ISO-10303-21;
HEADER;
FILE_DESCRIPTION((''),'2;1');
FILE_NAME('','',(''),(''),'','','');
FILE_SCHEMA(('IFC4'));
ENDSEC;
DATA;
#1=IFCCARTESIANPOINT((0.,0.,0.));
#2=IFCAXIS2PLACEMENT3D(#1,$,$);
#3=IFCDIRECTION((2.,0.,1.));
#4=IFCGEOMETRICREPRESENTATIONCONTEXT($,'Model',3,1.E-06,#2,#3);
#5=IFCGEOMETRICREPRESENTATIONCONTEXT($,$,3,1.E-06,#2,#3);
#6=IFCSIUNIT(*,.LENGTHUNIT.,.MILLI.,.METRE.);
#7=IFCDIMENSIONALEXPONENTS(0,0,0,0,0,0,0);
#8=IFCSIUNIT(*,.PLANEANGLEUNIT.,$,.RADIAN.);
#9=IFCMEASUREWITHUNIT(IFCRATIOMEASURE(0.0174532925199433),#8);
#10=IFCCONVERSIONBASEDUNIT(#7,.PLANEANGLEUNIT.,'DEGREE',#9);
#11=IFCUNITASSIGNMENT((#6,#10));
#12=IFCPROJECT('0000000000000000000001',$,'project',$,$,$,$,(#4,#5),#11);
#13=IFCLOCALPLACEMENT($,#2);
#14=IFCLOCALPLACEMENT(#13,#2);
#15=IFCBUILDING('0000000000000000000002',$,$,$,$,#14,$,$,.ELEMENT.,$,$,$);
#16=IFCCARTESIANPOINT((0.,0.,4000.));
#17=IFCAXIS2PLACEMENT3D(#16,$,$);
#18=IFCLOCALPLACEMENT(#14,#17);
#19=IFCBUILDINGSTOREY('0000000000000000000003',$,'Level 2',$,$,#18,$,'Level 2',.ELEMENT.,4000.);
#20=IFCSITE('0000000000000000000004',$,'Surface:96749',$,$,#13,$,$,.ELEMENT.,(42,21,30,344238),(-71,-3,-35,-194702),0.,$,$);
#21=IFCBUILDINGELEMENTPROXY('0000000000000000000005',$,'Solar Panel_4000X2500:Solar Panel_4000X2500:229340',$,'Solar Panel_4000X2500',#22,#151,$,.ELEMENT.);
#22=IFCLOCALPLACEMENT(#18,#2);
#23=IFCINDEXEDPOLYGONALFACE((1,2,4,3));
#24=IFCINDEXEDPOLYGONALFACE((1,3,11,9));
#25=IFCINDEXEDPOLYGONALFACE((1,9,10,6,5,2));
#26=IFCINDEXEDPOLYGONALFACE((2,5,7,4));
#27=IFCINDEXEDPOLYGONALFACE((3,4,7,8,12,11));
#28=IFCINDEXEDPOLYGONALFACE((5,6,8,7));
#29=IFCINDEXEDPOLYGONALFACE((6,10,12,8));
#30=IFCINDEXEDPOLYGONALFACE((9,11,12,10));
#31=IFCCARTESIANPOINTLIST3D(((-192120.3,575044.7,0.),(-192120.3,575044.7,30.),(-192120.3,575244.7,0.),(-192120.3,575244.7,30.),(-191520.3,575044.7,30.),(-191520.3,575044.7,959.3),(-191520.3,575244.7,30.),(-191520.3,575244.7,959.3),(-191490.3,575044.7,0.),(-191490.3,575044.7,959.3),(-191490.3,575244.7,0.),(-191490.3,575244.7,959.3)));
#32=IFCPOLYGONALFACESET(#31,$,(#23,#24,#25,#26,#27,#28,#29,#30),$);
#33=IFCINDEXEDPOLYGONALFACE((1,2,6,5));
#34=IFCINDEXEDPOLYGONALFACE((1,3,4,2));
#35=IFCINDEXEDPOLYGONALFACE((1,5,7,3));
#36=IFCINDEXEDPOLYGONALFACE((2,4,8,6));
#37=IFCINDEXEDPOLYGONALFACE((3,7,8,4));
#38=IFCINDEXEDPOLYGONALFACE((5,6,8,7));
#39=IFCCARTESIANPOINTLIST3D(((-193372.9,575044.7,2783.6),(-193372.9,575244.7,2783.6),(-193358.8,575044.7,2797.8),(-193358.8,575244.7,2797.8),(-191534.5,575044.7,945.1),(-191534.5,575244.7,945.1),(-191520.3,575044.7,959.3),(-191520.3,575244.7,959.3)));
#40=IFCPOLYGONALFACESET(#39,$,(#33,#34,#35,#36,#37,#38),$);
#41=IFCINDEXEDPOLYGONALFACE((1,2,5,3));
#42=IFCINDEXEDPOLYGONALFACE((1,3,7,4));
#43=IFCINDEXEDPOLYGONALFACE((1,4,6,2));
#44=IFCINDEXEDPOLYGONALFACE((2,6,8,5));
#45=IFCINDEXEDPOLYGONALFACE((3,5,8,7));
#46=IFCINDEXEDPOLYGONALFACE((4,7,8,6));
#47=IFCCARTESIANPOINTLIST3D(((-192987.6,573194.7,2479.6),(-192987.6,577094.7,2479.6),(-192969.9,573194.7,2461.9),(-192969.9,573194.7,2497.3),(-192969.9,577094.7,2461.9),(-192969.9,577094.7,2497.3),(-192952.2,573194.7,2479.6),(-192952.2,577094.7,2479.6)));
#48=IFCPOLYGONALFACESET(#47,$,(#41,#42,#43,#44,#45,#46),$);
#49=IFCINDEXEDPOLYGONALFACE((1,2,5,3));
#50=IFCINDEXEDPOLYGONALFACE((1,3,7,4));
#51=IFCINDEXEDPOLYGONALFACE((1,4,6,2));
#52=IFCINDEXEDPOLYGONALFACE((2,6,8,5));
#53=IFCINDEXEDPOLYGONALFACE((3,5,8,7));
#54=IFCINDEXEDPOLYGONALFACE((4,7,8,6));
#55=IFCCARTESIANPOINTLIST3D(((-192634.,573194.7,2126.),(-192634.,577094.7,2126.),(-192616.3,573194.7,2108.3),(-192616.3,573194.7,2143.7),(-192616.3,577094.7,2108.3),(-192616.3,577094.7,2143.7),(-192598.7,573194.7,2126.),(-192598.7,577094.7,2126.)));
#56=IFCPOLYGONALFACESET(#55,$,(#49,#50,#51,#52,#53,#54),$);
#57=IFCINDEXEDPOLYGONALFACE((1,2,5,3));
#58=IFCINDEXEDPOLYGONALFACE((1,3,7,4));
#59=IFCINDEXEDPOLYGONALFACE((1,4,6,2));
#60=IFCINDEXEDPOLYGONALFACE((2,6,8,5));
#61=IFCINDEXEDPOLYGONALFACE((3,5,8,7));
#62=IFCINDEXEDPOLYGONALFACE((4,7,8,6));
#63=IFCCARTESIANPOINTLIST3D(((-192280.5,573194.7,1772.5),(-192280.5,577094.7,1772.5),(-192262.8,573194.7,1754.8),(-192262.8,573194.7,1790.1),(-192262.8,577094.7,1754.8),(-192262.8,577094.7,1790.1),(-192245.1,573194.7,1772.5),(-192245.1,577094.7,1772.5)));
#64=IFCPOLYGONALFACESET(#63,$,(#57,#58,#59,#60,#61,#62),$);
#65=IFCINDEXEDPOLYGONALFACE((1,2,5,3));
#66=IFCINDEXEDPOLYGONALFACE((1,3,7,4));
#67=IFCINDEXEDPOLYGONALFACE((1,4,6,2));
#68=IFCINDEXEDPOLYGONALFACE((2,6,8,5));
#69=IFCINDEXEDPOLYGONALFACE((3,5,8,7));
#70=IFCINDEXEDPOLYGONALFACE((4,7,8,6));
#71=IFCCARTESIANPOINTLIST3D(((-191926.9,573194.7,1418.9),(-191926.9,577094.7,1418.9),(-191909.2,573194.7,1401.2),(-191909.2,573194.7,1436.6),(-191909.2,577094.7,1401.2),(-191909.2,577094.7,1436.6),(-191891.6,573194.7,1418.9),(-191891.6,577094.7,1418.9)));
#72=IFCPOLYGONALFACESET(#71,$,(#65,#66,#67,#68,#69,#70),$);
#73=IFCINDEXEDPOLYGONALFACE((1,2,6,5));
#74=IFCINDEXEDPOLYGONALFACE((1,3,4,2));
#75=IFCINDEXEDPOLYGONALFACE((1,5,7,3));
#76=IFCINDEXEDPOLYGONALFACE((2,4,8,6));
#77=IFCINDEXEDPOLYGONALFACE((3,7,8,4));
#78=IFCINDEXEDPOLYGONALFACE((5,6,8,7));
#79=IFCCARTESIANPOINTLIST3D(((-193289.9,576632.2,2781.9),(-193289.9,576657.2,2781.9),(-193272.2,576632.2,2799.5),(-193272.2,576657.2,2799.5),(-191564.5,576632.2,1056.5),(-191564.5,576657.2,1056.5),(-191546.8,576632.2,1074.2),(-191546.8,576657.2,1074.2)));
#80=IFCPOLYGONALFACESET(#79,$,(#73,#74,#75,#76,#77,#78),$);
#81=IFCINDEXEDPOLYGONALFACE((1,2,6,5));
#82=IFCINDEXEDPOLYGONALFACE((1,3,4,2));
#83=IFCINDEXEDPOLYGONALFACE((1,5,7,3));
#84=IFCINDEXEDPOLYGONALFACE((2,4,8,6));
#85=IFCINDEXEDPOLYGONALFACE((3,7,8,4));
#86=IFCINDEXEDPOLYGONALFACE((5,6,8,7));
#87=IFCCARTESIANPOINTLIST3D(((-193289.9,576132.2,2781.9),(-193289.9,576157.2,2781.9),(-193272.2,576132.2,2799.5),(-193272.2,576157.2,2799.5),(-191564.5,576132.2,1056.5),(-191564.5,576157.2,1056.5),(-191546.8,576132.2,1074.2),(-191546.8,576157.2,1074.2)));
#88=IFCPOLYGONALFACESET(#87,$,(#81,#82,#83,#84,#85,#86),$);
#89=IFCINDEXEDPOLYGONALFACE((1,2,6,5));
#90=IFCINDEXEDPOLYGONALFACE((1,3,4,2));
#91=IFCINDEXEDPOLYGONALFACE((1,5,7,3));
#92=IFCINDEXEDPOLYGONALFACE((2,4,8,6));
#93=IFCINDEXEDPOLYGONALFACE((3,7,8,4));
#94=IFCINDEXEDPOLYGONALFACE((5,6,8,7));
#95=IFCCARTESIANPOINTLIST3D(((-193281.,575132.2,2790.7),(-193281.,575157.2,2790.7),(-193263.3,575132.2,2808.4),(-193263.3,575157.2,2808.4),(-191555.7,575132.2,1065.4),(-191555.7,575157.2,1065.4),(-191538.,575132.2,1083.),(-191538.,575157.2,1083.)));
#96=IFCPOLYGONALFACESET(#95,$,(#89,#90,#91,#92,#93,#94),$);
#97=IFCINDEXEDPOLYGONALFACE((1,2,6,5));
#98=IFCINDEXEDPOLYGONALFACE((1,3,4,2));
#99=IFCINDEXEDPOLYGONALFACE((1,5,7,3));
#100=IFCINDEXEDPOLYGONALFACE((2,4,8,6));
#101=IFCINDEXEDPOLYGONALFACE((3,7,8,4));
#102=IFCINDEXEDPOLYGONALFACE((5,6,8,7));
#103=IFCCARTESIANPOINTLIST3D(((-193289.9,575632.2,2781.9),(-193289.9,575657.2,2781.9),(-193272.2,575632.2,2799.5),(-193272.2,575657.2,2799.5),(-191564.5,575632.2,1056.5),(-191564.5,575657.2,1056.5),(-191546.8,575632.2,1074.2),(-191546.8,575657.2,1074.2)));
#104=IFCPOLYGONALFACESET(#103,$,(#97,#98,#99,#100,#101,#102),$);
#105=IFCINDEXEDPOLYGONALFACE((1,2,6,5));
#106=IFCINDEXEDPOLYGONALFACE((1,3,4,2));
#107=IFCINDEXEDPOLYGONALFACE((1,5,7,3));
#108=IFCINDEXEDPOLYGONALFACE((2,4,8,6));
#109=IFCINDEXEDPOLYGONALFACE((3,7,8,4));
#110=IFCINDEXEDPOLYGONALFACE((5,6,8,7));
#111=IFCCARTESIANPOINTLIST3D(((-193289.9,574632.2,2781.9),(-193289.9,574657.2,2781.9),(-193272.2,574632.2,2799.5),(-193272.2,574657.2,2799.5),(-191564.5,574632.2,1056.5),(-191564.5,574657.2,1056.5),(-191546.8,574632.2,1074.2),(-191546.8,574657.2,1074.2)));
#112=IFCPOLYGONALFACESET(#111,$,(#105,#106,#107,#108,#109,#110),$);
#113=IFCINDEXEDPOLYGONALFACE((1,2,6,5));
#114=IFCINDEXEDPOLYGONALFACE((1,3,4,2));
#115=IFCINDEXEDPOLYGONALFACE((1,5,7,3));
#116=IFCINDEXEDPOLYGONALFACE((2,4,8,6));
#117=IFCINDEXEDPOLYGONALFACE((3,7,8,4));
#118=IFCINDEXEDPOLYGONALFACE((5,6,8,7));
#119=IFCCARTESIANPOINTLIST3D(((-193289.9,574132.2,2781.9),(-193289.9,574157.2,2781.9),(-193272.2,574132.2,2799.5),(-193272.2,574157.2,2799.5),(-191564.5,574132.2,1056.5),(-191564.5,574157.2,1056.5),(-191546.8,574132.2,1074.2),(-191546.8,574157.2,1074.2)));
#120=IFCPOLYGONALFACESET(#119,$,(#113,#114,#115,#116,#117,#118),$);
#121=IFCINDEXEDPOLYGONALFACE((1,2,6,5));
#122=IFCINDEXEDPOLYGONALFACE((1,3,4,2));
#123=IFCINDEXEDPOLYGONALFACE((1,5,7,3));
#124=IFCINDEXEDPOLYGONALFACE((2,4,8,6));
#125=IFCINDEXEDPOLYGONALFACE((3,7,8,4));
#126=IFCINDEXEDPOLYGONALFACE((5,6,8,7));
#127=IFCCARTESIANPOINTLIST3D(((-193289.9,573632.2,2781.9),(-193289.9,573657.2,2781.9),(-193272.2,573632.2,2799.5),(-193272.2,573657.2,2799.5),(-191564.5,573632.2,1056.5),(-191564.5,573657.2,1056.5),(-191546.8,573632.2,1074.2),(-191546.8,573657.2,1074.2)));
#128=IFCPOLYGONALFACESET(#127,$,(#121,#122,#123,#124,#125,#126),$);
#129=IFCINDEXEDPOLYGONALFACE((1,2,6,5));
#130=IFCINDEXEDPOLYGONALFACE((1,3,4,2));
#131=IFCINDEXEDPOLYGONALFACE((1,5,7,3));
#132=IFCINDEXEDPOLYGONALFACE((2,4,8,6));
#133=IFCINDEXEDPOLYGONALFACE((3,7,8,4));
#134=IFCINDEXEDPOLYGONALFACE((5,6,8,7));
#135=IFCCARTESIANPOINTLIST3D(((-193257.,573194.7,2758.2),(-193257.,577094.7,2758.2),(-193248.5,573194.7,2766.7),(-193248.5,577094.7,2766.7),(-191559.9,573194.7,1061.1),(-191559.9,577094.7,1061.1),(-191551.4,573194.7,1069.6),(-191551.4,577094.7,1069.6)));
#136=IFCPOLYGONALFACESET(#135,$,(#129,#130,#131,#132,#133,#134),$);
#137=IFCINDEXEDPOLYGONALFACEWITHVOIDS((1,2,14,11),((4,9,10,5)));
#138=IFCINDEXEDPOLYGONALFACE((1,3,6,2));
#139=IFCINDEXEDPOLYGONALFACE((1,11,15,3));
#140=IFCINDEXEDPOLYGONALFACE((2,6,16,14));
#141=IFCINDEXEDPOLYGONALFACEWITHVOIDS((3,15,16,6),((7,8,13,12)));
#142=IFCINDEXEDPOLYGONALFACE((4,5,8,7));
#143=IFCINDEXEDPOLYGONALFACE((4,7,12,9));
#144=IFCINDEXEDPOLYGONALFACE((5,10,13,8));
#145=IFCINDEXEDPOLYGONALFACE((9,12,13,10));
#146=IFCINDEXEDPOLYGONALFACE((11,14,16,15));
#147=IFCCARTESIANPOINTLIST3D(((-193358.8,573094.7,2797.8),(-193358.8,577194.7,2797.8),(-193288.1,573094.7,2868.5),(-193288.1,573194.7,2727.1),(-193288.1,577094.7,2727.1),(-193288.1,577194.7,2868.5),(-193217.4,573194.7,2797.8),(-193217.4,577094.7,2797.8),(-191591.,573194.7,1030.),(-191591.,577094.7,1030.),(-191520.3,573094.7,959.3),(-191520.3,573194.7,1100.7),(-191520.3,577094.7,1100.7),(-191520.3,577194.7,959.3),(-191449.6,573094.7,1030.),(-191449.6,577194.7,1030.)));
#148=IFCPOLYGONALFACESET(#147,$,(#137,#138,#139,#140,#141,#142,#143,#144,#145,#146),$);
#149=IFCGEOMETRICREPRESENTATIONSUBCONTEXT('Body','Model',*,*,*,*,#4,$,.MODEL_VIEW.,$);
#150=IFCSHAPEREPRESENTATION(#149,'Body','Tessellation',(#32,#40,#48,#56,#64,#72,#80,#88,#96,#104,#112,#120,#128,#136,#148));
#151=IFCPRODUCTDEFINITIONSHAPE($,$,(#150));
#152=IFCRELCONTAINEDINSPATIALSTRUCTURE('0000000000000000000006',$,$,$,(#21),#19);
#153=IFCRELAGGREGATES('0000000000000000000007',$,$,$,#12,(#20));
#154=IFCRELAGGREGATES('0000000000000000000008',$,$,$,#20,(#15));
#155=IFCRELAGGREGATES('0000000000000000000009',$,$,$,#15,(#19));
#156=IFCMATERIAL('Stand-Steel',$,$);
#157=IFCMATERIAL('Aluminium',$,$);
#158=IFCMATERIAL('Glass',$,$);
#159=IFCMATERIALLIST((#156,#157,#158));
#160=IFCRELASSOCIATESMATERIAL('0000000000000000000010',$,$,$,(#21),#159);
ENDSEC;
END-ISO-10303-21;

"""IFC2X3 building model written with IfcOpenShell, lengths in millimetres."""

from ifc_helpers import new_model, entity, si_unit, converted_unit, direction, frame, frame_2d, origin, origin_2d_with_axis, place, context, subcontext, project, spatial, polyline, rectangle, outline, extrude, source, transform, mapped, material, material_list, element, save


model = new_model("IFC2X3")

# Units and contexts
model_context = context("Model", 3, precision=1e-06, world=origin(), true_north=direction((2.0, 0.0, 1.0)))
context_of_model = context(None, 3, precision=1e-06, world=origin(), true_north=direction((2.0, 0.0, 1.0)))
body_context = subcontext(model_context, "Body", "Model", "MODEL_VIEW")
ifc_project = project(units=[si_unit("LENGTHUNIT", "METRE", prefix="MILLI"), converted_unit("PLANEANGLEUNIT", "DEGREE", entity("IfcRatioMeasure", 0.0174532925199433), si_unit("PLANEANGLEUNIT", "RADIAN"), dimensions=[0, 0, 0, 0, 0, 0, 0])], contexts=[model_context, context_of_model])

# Site, building, storey
site_placement = place(None, origin())
site = spatial("IfcSite", under=ifc_project, at=site_placement, Name="Surface:96749", CompositionType="ELEMENT", RefLatitude=(42, 21, 30, 344238), RefLongitude=(-71, -3, -35, -194702), RefElevation=0.0)
building_placement = place(site_placement, origin())
building = spatial("IfcBuilding", under=site, at=building_placement, CompositionType="ELEMENT")
storey_placement = place(building_placement, frame((0.0, 0.0, 4000.0)))
storey = spatial("IfcBuildingStorey", under=building, at=storey_placement, Name="Level 2", LongName="Level 2", CompositionType="ELEMENT", Elevation=4000.0)

# Building element proxy
ifc_material_1 = material(Name="Stand-Steel")
ifc_material_2 = material(Name="Aluminium")
ifc_material_3 = material(Name="Glass")
shared_shape = source(origin(), body_context, "Body", "SweptSolid", [
    extrude(outline(polyline([(-629.5, -220.0), (329.8, -220.0), (329.8, 410.0), (299.8, 410.0), (299.8, -190.0), (-629.5, -190.0), (-629.5, -220.0)])), frame((-190.0, -100.0, 299.8), z_axis=(0.0, 1.0, 0.0), x_axis=(0.0, 0.0, -1.0)), (0.0, 0.0, 1.0), 200.0),
    extrude(rectangle(XDim=20.0, YDim=200.0, at=frame_2d((0.0, 0.0), x_axis=(0.0, 1.0))), frame((-7.1, 0.0, 922.2), z_axis=(-0.707107, 0.0, 0.707107), x_axis=(0.0, 1.0, 0.0)), (0.0, 0.0, 1.0), 2600.0),
    extrude(rectangle(XDim=25.0, YDim=25.0, at=frame_2d((0.0, 0.0), x_axis=(1.0, 0.0))), frame((-1449.6, -1950.0, 2449.6), z_axis=(0.0, 1.0, 0.0), x_axis=(-0.707107, 0.0, -0.707107)), (0.0, 0.0, 1.0), 3900.0),
    extrude(rectangle(XDim=25.0, YDim=25.0, at=origin_2d_with_axis()), frame((-1096.0, -1950.0, 2096.0), z_axis=(0.0, 1.0, 0.0), x_axis=(-0.707107, 0.0, -0.707107)), (0.0, 0.0, 1.0), 3900.0),
    extrude(rectangle(XDim=25.0, YDim=25.0, at=origin_2d_with_axis()), frame((-742.5, -1950.0, 1742.5), z_axis=(0.0, 1.0, 0.0), x_axis=(-0.707107, 0.0, -0.707107)), (0.0, 0.0, 1.0), 3900.0),
    extrude(rectangle(XDim=25.0, YDim=25.0, at=frame_2d((0.0, 0.0), x_axis=(1.0, 0.0))), frame((-388.9, -1950.0, 1388.9), z_axis=(0.0, 1.0, 0.0), x_axis=(-0.707107, 0.0, -0.707107)), (0.0, 0.0, 1.0), 3900.0),
    extrude(rectangle(XDim=25.0, YDim=25.0, at=frame_2d((0.0, 0.0), x_axis=(0.0, 1.0))), frame((-35.4, 1500.0, 1035.4), z_axis=(-0.707107, 0.0, 0.707107), x_axis=(0.0, 1.0, 0.0)), (0.0, 0.0, 1.0), 2440.0),
    extrude(rectangle(XDim=25.0, YDim=25.0, at=frame_2d((0.0, 0.0), x_axis=(0.0, 1.0))), frame((-35.4, 1000.0, 1035.4), z_axis=(-0.707107, 0.0, 0.707107), x_axis=(0.0, 1.0, 0.0)), (0.0, 0.0, 1.0), 2440.0),
    extrude(rectangle(XDim=25.0, YDim=25.0, at=frame_2d((0.0, 0.0), x_axis=(0.0, 1.0))), frame((-26.5, 0.0, 1044.2), z_axis=(-0.707107, 0.0, 0.707107), x_axis=(0.0, -1.0, 0.0)), (0.0, 0.0, 1.0), 2440.0),
    extrude(rectangle(XDim=25.0, YDim=25.0, at=frame_2d((0.0, 0.0), x_axis=(0.0, 1.0))), frame((-35.4, 500.0, 1035.4), z_axis=(-0.707107, 0.0, 0.707107), x_axis=(0.0, 1.0, 0.0)), (0.0, 0.0, 1.0), 2440.0),
    extrude(rectangle(XDim=25.0, YDim=25.0, at=frame_2d((0.0, 0.0), x_axis=(0.0, 1.0))), frame((-35.4, -500.0, 1035.4), z_axis=(-0.707107, 0.0, 0.707107), x_axis=(0.0, 1.0, 0.0)), (0.0, 0.0, 1.0), 2440.0),
    extrude(rectangle(XDim=25.0, YDim=25.0, at=frame_2d((0.0, 0.0), x_axis=(0.0, 1.0))), frame((-35.4, -1000.0, 1035.4), z_axis=(-0.707107, 0.0, 0.707107), x_axis=(0.0, 1.0, 0.0)), (0.0, 0.0, 1.0), 2440.0),
    extrude(rectangle(XDim=25.0, YDim=25.0, at=frame_2d((0.0, 0.0), x_axis=(0.0, 1.0))), frame((-35.4, -1500.0, 1035.4), z_axis=(-0.707107, 0.0, 0.707107), x_axis=(0.0, 1.0, 0.0)), (0.0, 0.0, 1.0), 2440.0),
    extrude(rectangle(XDim=2400.0, YDim=12.0, at=frame_2d((0.0, 0.0), x_axis=(1.0, 0.0))), frame((-883.9, -1950.0, 1883.9), z_axis=(0.0, 1.0, 0.0), x_axis=(0.707107, 0.0, -0.707107)), (0.0, 0.0, 1.0), 3900.0),
    extrude(outline(polyline([(-2050.0, -1300.0), (2050.0, -1300.0), (2050.0, 1300.0), (-2050.0, 1300.0), (-2050.0, -1300.0)]), holes=[polyline([(1950.0, -1200.0), (-1950.0, -1200.0), (-1950.0, 1200.0), (1950.0, 1200.0), (1950.0, -1200.0)])]), frame((-919.2, 0.0, 1848.5), z_axis=(0.707107, 0.0, 0.707107), x_axis=(0.0, 1.0, 0.0)), (0.0, 0.0, 1.0), 100.0),
])
ifc_material_list_1 = material_list([ifc_material_1, ifc_material_2, ifc_material_3])
proxy_1_placement = place(storey_placement, frame((-191520.3, 575144.7, 30.0)))
element("IfcBuildingElementProxy", 1, at=proxy_1_placement, inside=storey, material=ifc_material_list_1, Name="Solar Panel_4000X2500:Solar Panel_4000X2500:229340", ObjectType="Solar Panel_4000X2500", CompositionType="ELEMENT", context=body_context, shape_type="MappedRepresentation", body=[
    mapped(shared_shape, transform((0.0, 0.0, 0.0), scale=1.0)),
])

save(model, "model.ifc")
